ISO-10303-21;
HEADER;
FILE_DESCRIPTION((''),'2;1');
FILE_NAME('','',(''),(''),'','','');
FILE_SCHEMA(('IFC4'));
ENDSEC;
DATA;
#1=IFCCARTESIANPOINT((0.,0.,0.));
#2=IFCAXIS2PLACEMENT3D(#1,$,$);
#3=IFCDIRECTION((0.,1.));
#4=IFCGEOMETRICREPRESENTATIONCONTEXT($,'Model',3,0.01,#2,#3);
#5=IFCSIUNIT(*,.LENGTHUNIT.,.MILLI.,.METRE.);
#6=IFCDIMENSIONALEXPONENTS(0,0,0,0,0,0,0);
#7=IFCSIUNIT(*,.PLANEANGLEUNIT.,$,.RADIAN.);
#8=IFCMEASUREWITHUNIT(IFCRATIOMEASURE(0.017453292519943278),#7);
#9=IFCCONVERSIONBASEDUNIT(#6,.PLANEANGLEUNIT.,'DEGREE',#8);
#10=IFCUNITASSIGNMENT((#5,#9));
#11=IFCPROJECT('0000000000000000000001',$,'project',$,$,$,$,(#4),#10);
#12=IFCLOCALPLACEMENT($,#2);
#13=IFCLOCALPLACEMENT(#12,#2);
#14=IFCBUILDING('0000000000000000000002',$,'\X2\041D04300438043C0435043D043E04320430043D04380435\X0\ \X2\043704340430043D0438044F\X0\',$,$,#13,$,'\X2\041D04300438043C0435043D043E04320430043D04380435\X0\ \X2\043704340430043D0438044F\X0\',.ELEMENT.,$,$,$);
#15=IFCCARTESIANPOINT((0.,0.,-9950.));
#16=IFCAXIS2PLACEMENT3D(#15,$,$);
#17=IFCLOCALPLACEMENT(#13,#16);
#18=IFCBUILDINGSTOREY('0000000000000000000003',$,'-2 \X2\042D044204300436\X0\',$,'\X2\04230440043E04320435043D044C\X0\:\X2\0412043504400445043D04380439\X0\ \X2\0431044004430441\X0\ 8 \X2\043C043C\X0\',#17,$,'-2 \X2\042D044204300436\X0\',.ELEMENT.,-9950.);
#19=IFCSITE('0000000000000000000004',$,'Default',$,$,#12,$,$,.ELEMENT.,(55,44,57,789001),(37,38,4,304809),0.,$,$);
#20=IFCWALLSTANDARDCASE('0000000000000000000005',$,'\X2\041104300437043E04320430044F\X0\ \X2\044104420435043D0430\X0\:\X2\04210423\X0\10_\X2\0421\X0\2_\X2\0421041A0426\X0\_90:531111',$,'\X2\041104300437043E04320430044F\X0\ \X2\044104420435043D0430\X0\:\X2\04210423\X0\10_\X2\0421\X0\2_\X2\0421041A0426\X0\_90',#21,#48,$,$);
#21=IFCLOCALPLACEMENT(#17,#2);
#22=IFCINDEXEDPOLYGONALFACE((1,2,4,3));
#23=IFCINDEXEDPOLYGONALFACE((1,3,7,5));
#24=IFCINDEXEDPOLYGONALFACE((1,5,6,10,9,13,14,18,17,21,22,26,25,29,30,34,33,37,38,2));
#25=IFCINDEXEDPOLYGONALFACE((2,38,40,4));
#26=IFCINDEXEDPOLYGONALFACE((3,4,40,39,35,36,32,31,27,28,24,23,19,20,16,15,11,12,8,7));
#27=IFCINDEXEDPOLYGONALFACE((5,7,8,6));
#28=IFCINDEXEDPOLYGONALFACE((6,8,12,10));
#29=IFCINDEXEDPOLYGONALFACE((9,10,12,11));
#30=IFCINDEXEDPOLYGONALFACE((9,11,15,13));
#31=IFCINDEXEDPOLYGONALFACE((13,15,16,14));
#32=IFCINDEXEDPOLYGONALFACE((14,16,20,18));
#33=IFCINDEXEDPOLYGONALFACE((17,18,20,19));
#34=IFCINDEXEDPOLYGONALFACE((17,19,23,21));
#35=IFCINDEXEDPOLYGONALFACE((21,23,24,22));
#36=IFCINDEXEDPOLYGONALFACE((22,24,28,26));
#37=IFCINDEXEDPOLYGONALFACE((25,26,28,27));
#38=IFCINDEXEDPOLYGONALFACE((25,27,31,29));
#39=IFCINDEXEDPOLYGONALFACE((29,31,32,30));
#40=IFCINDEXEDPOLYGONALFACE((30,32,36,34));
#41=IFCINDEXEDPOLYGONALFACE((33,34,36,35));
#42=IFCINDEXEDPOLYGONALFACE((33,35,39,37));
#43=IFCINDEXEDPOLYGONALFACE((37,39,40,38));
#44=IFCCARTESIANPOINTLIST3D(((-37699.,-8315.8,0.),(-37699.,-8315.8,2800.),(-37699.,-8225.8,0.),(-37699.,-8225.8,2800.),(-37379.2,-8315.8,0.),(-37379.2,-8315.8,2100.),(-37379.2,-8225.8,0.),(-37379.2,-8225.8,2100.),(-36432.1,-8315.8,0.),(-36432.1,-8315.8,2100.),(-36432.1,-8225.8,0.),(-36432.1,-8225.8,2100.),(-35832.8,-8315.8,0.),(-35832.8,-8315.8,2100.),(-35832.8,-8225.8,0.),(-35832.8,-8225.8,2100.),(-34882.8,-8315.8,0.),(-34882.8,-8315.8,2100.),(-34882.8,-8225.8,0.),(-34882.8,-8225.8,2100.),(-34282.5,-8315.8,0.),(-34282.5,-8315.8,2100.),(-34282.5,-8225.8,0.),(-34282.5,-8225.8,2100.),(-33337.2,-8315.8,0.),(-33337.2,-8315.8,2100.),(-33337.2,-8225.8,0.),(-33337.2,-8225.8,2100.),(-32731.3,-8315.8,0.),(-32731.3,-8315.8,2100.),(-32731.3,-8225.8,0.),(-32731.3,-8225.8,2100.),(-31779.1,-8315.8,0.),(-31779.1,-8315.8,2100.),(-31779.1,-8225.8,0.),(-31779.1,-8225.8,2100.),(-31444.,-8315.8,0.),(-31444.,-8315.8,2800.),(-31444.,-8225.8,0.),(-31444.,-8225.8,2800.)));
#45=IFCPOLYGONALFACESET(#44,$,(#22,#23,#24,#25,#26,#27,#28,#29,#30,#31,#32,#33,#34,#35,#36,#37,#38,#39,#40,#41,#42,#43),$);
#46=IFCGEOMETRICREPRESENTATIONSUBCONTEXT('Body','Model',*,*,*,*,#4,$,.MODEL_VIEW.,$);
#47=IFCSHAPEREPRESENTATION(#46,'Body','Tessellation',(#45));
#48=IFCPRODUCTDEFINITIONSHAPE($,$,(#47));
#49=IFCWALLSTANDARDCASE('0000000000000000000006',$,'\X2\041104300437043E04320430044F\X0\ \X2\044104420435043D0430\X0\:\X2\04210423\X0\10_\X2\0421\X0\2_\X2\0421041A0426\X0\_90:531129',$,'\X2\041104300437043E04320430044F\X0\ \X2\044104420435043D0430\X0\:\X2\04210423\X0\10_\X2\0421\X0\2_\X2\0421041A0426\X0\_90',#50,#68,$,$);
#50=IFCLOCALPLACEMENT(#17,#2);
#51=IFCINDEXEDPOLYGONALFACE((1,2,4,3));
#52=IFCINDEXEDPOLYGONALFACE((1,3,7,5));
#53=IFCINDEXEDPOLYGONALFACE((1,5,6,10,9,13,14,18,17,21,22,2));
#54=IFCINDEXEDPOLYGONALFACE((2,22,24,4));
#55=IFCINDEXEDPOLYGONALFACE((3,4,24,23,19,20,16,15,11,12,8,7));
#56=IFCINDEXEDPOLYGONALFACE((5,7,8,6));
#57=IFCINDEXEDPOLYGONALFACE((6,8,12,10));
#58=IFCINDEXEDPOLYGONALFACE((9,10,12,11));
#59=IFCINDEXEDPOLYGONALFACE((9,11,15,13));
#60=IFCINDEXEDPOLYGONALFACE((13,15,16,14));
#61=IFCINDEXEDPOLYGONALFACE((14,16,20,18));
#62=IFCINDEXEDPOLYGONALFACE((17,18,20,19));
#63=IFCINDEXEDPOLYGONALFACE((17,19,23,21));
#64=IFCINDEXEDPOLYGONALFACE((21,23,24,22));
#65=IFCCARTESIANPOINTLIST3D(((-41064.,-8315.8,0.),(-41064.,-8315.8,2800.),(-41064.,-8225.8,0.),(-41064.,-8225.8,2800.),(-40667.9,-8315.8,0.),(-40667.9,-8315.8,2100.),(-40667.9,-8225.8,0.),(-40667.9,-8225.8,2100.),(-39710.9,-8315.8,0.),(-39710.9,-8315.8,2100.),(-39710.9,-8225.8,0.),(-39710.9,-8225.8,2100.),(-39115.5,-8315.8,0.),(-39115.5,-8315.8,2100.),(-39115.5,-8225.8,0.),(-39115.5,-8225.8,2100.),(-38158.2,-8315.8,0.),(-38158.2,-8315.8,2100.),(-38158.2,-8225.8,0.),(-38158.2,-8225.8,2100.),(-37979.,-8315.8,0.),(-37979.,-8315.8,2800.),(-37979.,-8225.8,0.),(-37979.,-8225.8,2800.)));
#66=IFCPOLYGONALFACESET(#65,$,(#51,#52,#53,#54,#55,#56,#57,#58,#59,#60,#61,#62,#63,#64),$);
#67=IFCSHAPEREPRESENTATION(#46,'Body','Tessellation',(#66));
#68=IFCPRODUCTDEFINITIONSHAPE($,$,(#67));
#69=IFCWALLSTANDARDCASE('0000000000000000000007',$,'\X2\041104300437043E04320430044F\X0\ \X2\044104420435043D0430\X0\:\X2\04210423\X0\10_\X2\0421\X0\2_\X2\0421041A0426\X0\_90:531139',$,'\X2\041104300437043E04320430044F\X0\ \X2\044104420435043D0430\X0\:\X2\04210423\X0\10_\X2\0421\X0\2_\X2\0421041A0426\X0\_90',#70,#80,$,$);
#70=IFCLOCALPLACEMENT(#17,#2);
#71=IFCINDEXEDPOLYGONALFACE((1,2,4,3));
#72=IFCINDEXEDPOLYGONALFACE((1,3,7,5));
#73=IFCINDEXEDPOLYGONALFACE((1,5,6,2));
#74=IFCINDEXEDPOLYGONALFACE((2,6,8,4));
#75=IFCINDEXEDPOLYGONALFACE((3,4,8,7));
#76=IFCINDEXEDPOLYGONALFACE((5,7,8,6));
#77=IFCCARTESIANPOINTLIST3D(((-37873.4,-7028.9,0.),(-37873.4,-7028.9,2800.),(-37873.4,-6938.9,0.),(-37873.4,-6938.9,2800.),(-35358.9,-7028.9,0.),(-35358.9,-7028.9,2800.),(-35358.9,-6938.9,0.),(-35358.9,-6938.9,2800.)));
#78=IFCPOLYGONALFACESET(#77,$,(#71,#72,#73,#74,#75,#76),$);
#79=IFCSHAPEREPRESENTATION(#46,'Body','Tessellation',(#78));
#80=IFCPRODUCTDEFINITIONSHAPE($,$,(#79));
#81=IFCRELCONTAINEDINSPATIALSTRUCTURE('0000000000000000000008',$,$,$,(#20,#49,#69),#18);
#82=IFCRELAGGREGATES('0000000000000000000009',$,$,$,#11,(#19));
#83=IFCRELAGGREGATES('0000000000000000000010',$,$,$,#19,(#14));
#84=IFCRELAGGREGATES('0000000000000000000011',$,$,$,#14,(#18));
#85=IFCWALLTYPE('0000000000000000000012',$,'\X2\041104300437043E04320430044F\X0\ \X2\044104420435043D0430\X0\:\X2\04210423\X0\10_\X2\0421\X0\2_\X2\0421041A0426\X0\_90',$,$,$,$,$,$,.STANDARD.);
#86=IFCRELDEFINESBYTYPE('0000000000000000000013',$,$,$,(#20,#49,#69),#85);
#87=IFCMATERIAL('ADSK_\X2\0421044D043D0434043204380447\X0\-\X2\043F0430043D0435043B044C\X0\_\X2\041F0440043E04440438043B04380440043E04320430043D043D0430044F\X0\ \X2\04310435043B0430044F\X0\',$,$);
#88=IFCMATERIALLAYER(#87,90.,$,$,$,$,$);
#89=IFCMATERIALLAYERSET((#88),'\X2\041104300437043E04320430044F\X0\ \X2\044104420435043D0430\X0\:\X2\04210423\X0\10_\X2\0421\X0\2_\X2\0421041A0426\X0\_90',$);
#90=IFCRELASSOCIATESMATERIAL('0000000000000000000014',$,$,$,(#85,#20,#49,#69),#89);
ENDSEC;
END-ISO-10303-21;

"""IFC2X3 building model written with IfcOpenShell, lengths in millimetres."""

from ifc_helpers import new_model, entity, si_unit, converted_unit, direction, frame, frame_2d, origin, place, context, subcontext, project, spatial, rectangle, extrude, material, layer, layer_set, layer_usage, type_object, element, save


model = new_model("IFC2X3")

# Units and contexts
model_context = context("Model", 3, precision=0.01, world=origin(), true_north=direction((0.0, 1.0)))
body_context = subcontext(model_context, "Body", "Model", "MODEL_VIEW")
ifc_project = project(units=[si_unit("LENGTHUNIT", "METRE", prefix="MILLI"), converted_unit("PLANEANGLEUNIT", "DEGREE", entity("IfcRatioMeasure", 0.017453292519943278), si_unit("PLANEANGLEUNIT", "RADIAN"), dimensions=[0, 0, 0, 0, 0, 0, 0])], contexts=[model_context])

# Site, building, storey
site_placement = place(None, origin())
site = spatial("IfcSite", under=ifc_project, at=site_placement, Name="Default", CompositionType="ELEMENT", RefLatitude=(55, 44, 57, 789001), RefLongitude=(37, 38, 4, 304809), RefElevation=0.0)
building_placement = place(site_placement, origin())
building = spatial("IfcBuilding", under=site, at=building_placement, Name="Наименование здания", LongName="Наименование здания", CompositionType="ELEMENT")
storey_placement = place(building_placement, frame((0.0, 0.0, -9950.0)))
storey = spatial("IfcBuildingStorey", under=building, at=storey_placement, Name="-2 Этаж", ObjectType="Уровень:Верхний брус 8 мм", LongName="-2 Этаж", CompositionType="ELEMENT", Elevation=-9950.0)

# Shared definitions
ifc_material_1 = material(Name="ADSK_Сэндвич-панель_Профилированная белая")
ifc_layer_1 = layer(ifc_material_1, 90.0)
ifc_layer_set_1 = layer_set([ifc_layer_1], Name="Базовая стена:СУ10_С2_СКЦ_90")
ifc_layer_usage_1 = layer_usage(ifc_layer_set_1, "AXIS2", "NEGATIVE", 45.0)
wall_type_1 = type_object("IfcWallType", Name="Базовая стена:СУ10_С2_СКЦ_90", PredefinedType="STANDARD", material=ifc_layer_set_1)

# Walls, openings
wall_1_placement = place(storey_placement, frame((-31444.0, -8270.8, 0.0), z_axis=(0.0, 0.0, 1.0), x_axis=(-1.0, 0.0, 0.0)))
wall_1 = element("IfcWallStandardCase", 1, at=wall_1_placement, inside=storey, type_object=wall_type_1, material=ifc_layer_usage_1, Name="Базовая стена:СУ10_С2_СКЦ_90:531111", ObjectType="Базовая стена:СУ10_С2_СКЦ_90", context=body_context, shape_type="SweptSolid", body=[
    extrude(rectangle(XDim=6255.1, YDim=90.0, at=frame_2d((3127.5, 0.0), x_axis=(1.0, 0.0))), origin(), (0.0, 0.0, 1.0), 2800.0),
])
opening_1_placement = place(wall_1_placement, origin())
element("IfcOpeningElement", 2, at=opening_1_placement, cuts=wall_1, ObjectType="Opening", context=body_context, shape_type="SweptSolid", body=[
    extrude(rectangle(XDim=2100.0, YDim=947.1, at=frame_2d((0.0, 0.0), x_axis=(1.0, 0.0))), frame((5461.7, -45.0, 1050.0), z_axis=(0.0, 1.0, 0.0), x_axis=(0.0, 0.0, -1.0)), (0.0, 0.0, 1.0), 90.0),
])
opening_2_placement = place(wall_1_placement, origin())
element("IfcOpeningElement", 3, at=opening_2_placement, cuts=wall_1, ObjectType="Opening", context=body_context, shape_type="SweptSolid", body=[
    extrude(rectangle(XDim=2100.0, YDim=950.0, at=frame_2d((0.0, 0.0), x_axis=(1.0, 0.0))), frame((3913.8, -45.0, 1050.0), z_axis=(0.0, 1.0, 0.0), x_axis=(0.0, 0.0, -1.0)), (0.0, 0.0, 1.0), 90.0),
])
opening_3_placement = place(wall_1_placement, origin())
element("IfcOpeningElement", 4, at=opening_3_placement, cuts=wall_1, ObjectType="Opening", context=body_context, shape_type="SweptSolid", body=[
    extrude(rectangle(XDim=2100.0, YDim=945.4, at=frame_2d((0.0, 0.0), x_axis=(1.0, 0.0))), frame((2365.9, -45.0, 1050.0), z_axis=(0.0, 1.0, 0.0), x_axis=(0.0, 0.0, -1.0)), (0.0, 0.0, 1.0), 90.0),
])
opening_4_placement = place(wall_1_placement, origin())
element("IfcOpeningElement", 5, at=opening_4_placement, cuts=wall_1, ObjectType="Opening", context=body_context, shape_type="SweptSolid", body=[
    extrude(rectangle(XDim=2100.0, YDim=952.2, at=frame_2d((0.0, 0.0), x_axis=(1.0, 0.0))), frame((811.2, -45.0, 1050.0), z_axis=(0.0, 1.0, 0.0), x_axis=(0.0, 0.0, -1.0)), (0.0, 0.0, 1.0), 90.0),
])
wall_2_placement = place(storey_placement, frame((-37979.0, -8270.8, 0.0), z_axis=(0.0, 0.0, 1.0), x_axis=(-1.0, 0.0, 0.0)))
wall_2 = element("IfcWallStandardCase", 6, at=wall_2_placement, inside=storey, type_object=wall_type_1, material=ifc_layer_usage_1, Name="Базовая стена:СУ10_С2_СКЦ_90:531129", ObjectType="Базовая стена:СУ10_С2_СКЦ_90", context=body_context, shape_type="SweptSolid", body=[
    extrude(rectangle(XDim=3084.9, YDim=90.0, at=frame_2d((1542.5, 0.0), x_axis=(1.0, 0.0))), origin(), (0.0, 0.0, 1.0), 2800.0),
])
opening_5_placement = place(wall_2_placement, origin())
element("IfcOpeningElement", 7, at=opening_5_placement, cuts=wall_2, ObjectType="Opening", context=body_context, shape_type="SweptSolid", body=[
    extrude(rectangle(XDim=2100.0, YDim=957.0, at=frame_2d((0.0, 0.0), x_axis=(1.0, 0.0))), frame((2210.3, -45.0, 1050.0), z_axis=(0.0, 1.0, 0.0), x_axis=(0.0, 0.0, -1.0)), (0.0, 0.0, 1.0), 90.0),
])
opening_6_placement = place(wall_2_placement, origin())
element("IfcOpeningElement", 8, at=opening_6_placement, cuts=wall_2, ObjectType="Opening", context=body_context, shape_type="SweptSolid", body=[
    extrude(rectangle(XDim=2100.0, YDim=957.4, at=frame_2d((0.0, 0.0), x_axis=(1.0, 0.0))), frame((657.8, -45.0, 1050.0), z_axis=(0.0, 1.0, 0.0), x_axis=(0.0, 0.0, -1.0)), (0.0, 0.0, 1.0), 90.0),
])

# Wall
wall_3_placement = place(storey_placement, frame((-35358.9, -6983.9, 0.0), z_axis=(0.0, 0.0, 1.0), x_axis=(-1.0, 0.0, 0.0)))
element("IfcWallStandardCase", 9, at=wall_3_placement, inside=storey, type_object=wall_type_1, material=ifc_layer_usage_1, Name="Базовая стена:СУ10_С2_СКЦ_90:531139", ObjectType="Базовая стена:СУ10_С2_СКЦ_90", context=body_context, shape_type="SweptSolid", body=[
    extrude(rectangle(XDim=2514.5, YDim=90.0, at=frame_2d((1257.3, 0.0), x_axis=(-1.0, 0.0))), origin(), (0.0, 0.0, 1.0), 2800.0),
])

save(model, "model.ifc")
